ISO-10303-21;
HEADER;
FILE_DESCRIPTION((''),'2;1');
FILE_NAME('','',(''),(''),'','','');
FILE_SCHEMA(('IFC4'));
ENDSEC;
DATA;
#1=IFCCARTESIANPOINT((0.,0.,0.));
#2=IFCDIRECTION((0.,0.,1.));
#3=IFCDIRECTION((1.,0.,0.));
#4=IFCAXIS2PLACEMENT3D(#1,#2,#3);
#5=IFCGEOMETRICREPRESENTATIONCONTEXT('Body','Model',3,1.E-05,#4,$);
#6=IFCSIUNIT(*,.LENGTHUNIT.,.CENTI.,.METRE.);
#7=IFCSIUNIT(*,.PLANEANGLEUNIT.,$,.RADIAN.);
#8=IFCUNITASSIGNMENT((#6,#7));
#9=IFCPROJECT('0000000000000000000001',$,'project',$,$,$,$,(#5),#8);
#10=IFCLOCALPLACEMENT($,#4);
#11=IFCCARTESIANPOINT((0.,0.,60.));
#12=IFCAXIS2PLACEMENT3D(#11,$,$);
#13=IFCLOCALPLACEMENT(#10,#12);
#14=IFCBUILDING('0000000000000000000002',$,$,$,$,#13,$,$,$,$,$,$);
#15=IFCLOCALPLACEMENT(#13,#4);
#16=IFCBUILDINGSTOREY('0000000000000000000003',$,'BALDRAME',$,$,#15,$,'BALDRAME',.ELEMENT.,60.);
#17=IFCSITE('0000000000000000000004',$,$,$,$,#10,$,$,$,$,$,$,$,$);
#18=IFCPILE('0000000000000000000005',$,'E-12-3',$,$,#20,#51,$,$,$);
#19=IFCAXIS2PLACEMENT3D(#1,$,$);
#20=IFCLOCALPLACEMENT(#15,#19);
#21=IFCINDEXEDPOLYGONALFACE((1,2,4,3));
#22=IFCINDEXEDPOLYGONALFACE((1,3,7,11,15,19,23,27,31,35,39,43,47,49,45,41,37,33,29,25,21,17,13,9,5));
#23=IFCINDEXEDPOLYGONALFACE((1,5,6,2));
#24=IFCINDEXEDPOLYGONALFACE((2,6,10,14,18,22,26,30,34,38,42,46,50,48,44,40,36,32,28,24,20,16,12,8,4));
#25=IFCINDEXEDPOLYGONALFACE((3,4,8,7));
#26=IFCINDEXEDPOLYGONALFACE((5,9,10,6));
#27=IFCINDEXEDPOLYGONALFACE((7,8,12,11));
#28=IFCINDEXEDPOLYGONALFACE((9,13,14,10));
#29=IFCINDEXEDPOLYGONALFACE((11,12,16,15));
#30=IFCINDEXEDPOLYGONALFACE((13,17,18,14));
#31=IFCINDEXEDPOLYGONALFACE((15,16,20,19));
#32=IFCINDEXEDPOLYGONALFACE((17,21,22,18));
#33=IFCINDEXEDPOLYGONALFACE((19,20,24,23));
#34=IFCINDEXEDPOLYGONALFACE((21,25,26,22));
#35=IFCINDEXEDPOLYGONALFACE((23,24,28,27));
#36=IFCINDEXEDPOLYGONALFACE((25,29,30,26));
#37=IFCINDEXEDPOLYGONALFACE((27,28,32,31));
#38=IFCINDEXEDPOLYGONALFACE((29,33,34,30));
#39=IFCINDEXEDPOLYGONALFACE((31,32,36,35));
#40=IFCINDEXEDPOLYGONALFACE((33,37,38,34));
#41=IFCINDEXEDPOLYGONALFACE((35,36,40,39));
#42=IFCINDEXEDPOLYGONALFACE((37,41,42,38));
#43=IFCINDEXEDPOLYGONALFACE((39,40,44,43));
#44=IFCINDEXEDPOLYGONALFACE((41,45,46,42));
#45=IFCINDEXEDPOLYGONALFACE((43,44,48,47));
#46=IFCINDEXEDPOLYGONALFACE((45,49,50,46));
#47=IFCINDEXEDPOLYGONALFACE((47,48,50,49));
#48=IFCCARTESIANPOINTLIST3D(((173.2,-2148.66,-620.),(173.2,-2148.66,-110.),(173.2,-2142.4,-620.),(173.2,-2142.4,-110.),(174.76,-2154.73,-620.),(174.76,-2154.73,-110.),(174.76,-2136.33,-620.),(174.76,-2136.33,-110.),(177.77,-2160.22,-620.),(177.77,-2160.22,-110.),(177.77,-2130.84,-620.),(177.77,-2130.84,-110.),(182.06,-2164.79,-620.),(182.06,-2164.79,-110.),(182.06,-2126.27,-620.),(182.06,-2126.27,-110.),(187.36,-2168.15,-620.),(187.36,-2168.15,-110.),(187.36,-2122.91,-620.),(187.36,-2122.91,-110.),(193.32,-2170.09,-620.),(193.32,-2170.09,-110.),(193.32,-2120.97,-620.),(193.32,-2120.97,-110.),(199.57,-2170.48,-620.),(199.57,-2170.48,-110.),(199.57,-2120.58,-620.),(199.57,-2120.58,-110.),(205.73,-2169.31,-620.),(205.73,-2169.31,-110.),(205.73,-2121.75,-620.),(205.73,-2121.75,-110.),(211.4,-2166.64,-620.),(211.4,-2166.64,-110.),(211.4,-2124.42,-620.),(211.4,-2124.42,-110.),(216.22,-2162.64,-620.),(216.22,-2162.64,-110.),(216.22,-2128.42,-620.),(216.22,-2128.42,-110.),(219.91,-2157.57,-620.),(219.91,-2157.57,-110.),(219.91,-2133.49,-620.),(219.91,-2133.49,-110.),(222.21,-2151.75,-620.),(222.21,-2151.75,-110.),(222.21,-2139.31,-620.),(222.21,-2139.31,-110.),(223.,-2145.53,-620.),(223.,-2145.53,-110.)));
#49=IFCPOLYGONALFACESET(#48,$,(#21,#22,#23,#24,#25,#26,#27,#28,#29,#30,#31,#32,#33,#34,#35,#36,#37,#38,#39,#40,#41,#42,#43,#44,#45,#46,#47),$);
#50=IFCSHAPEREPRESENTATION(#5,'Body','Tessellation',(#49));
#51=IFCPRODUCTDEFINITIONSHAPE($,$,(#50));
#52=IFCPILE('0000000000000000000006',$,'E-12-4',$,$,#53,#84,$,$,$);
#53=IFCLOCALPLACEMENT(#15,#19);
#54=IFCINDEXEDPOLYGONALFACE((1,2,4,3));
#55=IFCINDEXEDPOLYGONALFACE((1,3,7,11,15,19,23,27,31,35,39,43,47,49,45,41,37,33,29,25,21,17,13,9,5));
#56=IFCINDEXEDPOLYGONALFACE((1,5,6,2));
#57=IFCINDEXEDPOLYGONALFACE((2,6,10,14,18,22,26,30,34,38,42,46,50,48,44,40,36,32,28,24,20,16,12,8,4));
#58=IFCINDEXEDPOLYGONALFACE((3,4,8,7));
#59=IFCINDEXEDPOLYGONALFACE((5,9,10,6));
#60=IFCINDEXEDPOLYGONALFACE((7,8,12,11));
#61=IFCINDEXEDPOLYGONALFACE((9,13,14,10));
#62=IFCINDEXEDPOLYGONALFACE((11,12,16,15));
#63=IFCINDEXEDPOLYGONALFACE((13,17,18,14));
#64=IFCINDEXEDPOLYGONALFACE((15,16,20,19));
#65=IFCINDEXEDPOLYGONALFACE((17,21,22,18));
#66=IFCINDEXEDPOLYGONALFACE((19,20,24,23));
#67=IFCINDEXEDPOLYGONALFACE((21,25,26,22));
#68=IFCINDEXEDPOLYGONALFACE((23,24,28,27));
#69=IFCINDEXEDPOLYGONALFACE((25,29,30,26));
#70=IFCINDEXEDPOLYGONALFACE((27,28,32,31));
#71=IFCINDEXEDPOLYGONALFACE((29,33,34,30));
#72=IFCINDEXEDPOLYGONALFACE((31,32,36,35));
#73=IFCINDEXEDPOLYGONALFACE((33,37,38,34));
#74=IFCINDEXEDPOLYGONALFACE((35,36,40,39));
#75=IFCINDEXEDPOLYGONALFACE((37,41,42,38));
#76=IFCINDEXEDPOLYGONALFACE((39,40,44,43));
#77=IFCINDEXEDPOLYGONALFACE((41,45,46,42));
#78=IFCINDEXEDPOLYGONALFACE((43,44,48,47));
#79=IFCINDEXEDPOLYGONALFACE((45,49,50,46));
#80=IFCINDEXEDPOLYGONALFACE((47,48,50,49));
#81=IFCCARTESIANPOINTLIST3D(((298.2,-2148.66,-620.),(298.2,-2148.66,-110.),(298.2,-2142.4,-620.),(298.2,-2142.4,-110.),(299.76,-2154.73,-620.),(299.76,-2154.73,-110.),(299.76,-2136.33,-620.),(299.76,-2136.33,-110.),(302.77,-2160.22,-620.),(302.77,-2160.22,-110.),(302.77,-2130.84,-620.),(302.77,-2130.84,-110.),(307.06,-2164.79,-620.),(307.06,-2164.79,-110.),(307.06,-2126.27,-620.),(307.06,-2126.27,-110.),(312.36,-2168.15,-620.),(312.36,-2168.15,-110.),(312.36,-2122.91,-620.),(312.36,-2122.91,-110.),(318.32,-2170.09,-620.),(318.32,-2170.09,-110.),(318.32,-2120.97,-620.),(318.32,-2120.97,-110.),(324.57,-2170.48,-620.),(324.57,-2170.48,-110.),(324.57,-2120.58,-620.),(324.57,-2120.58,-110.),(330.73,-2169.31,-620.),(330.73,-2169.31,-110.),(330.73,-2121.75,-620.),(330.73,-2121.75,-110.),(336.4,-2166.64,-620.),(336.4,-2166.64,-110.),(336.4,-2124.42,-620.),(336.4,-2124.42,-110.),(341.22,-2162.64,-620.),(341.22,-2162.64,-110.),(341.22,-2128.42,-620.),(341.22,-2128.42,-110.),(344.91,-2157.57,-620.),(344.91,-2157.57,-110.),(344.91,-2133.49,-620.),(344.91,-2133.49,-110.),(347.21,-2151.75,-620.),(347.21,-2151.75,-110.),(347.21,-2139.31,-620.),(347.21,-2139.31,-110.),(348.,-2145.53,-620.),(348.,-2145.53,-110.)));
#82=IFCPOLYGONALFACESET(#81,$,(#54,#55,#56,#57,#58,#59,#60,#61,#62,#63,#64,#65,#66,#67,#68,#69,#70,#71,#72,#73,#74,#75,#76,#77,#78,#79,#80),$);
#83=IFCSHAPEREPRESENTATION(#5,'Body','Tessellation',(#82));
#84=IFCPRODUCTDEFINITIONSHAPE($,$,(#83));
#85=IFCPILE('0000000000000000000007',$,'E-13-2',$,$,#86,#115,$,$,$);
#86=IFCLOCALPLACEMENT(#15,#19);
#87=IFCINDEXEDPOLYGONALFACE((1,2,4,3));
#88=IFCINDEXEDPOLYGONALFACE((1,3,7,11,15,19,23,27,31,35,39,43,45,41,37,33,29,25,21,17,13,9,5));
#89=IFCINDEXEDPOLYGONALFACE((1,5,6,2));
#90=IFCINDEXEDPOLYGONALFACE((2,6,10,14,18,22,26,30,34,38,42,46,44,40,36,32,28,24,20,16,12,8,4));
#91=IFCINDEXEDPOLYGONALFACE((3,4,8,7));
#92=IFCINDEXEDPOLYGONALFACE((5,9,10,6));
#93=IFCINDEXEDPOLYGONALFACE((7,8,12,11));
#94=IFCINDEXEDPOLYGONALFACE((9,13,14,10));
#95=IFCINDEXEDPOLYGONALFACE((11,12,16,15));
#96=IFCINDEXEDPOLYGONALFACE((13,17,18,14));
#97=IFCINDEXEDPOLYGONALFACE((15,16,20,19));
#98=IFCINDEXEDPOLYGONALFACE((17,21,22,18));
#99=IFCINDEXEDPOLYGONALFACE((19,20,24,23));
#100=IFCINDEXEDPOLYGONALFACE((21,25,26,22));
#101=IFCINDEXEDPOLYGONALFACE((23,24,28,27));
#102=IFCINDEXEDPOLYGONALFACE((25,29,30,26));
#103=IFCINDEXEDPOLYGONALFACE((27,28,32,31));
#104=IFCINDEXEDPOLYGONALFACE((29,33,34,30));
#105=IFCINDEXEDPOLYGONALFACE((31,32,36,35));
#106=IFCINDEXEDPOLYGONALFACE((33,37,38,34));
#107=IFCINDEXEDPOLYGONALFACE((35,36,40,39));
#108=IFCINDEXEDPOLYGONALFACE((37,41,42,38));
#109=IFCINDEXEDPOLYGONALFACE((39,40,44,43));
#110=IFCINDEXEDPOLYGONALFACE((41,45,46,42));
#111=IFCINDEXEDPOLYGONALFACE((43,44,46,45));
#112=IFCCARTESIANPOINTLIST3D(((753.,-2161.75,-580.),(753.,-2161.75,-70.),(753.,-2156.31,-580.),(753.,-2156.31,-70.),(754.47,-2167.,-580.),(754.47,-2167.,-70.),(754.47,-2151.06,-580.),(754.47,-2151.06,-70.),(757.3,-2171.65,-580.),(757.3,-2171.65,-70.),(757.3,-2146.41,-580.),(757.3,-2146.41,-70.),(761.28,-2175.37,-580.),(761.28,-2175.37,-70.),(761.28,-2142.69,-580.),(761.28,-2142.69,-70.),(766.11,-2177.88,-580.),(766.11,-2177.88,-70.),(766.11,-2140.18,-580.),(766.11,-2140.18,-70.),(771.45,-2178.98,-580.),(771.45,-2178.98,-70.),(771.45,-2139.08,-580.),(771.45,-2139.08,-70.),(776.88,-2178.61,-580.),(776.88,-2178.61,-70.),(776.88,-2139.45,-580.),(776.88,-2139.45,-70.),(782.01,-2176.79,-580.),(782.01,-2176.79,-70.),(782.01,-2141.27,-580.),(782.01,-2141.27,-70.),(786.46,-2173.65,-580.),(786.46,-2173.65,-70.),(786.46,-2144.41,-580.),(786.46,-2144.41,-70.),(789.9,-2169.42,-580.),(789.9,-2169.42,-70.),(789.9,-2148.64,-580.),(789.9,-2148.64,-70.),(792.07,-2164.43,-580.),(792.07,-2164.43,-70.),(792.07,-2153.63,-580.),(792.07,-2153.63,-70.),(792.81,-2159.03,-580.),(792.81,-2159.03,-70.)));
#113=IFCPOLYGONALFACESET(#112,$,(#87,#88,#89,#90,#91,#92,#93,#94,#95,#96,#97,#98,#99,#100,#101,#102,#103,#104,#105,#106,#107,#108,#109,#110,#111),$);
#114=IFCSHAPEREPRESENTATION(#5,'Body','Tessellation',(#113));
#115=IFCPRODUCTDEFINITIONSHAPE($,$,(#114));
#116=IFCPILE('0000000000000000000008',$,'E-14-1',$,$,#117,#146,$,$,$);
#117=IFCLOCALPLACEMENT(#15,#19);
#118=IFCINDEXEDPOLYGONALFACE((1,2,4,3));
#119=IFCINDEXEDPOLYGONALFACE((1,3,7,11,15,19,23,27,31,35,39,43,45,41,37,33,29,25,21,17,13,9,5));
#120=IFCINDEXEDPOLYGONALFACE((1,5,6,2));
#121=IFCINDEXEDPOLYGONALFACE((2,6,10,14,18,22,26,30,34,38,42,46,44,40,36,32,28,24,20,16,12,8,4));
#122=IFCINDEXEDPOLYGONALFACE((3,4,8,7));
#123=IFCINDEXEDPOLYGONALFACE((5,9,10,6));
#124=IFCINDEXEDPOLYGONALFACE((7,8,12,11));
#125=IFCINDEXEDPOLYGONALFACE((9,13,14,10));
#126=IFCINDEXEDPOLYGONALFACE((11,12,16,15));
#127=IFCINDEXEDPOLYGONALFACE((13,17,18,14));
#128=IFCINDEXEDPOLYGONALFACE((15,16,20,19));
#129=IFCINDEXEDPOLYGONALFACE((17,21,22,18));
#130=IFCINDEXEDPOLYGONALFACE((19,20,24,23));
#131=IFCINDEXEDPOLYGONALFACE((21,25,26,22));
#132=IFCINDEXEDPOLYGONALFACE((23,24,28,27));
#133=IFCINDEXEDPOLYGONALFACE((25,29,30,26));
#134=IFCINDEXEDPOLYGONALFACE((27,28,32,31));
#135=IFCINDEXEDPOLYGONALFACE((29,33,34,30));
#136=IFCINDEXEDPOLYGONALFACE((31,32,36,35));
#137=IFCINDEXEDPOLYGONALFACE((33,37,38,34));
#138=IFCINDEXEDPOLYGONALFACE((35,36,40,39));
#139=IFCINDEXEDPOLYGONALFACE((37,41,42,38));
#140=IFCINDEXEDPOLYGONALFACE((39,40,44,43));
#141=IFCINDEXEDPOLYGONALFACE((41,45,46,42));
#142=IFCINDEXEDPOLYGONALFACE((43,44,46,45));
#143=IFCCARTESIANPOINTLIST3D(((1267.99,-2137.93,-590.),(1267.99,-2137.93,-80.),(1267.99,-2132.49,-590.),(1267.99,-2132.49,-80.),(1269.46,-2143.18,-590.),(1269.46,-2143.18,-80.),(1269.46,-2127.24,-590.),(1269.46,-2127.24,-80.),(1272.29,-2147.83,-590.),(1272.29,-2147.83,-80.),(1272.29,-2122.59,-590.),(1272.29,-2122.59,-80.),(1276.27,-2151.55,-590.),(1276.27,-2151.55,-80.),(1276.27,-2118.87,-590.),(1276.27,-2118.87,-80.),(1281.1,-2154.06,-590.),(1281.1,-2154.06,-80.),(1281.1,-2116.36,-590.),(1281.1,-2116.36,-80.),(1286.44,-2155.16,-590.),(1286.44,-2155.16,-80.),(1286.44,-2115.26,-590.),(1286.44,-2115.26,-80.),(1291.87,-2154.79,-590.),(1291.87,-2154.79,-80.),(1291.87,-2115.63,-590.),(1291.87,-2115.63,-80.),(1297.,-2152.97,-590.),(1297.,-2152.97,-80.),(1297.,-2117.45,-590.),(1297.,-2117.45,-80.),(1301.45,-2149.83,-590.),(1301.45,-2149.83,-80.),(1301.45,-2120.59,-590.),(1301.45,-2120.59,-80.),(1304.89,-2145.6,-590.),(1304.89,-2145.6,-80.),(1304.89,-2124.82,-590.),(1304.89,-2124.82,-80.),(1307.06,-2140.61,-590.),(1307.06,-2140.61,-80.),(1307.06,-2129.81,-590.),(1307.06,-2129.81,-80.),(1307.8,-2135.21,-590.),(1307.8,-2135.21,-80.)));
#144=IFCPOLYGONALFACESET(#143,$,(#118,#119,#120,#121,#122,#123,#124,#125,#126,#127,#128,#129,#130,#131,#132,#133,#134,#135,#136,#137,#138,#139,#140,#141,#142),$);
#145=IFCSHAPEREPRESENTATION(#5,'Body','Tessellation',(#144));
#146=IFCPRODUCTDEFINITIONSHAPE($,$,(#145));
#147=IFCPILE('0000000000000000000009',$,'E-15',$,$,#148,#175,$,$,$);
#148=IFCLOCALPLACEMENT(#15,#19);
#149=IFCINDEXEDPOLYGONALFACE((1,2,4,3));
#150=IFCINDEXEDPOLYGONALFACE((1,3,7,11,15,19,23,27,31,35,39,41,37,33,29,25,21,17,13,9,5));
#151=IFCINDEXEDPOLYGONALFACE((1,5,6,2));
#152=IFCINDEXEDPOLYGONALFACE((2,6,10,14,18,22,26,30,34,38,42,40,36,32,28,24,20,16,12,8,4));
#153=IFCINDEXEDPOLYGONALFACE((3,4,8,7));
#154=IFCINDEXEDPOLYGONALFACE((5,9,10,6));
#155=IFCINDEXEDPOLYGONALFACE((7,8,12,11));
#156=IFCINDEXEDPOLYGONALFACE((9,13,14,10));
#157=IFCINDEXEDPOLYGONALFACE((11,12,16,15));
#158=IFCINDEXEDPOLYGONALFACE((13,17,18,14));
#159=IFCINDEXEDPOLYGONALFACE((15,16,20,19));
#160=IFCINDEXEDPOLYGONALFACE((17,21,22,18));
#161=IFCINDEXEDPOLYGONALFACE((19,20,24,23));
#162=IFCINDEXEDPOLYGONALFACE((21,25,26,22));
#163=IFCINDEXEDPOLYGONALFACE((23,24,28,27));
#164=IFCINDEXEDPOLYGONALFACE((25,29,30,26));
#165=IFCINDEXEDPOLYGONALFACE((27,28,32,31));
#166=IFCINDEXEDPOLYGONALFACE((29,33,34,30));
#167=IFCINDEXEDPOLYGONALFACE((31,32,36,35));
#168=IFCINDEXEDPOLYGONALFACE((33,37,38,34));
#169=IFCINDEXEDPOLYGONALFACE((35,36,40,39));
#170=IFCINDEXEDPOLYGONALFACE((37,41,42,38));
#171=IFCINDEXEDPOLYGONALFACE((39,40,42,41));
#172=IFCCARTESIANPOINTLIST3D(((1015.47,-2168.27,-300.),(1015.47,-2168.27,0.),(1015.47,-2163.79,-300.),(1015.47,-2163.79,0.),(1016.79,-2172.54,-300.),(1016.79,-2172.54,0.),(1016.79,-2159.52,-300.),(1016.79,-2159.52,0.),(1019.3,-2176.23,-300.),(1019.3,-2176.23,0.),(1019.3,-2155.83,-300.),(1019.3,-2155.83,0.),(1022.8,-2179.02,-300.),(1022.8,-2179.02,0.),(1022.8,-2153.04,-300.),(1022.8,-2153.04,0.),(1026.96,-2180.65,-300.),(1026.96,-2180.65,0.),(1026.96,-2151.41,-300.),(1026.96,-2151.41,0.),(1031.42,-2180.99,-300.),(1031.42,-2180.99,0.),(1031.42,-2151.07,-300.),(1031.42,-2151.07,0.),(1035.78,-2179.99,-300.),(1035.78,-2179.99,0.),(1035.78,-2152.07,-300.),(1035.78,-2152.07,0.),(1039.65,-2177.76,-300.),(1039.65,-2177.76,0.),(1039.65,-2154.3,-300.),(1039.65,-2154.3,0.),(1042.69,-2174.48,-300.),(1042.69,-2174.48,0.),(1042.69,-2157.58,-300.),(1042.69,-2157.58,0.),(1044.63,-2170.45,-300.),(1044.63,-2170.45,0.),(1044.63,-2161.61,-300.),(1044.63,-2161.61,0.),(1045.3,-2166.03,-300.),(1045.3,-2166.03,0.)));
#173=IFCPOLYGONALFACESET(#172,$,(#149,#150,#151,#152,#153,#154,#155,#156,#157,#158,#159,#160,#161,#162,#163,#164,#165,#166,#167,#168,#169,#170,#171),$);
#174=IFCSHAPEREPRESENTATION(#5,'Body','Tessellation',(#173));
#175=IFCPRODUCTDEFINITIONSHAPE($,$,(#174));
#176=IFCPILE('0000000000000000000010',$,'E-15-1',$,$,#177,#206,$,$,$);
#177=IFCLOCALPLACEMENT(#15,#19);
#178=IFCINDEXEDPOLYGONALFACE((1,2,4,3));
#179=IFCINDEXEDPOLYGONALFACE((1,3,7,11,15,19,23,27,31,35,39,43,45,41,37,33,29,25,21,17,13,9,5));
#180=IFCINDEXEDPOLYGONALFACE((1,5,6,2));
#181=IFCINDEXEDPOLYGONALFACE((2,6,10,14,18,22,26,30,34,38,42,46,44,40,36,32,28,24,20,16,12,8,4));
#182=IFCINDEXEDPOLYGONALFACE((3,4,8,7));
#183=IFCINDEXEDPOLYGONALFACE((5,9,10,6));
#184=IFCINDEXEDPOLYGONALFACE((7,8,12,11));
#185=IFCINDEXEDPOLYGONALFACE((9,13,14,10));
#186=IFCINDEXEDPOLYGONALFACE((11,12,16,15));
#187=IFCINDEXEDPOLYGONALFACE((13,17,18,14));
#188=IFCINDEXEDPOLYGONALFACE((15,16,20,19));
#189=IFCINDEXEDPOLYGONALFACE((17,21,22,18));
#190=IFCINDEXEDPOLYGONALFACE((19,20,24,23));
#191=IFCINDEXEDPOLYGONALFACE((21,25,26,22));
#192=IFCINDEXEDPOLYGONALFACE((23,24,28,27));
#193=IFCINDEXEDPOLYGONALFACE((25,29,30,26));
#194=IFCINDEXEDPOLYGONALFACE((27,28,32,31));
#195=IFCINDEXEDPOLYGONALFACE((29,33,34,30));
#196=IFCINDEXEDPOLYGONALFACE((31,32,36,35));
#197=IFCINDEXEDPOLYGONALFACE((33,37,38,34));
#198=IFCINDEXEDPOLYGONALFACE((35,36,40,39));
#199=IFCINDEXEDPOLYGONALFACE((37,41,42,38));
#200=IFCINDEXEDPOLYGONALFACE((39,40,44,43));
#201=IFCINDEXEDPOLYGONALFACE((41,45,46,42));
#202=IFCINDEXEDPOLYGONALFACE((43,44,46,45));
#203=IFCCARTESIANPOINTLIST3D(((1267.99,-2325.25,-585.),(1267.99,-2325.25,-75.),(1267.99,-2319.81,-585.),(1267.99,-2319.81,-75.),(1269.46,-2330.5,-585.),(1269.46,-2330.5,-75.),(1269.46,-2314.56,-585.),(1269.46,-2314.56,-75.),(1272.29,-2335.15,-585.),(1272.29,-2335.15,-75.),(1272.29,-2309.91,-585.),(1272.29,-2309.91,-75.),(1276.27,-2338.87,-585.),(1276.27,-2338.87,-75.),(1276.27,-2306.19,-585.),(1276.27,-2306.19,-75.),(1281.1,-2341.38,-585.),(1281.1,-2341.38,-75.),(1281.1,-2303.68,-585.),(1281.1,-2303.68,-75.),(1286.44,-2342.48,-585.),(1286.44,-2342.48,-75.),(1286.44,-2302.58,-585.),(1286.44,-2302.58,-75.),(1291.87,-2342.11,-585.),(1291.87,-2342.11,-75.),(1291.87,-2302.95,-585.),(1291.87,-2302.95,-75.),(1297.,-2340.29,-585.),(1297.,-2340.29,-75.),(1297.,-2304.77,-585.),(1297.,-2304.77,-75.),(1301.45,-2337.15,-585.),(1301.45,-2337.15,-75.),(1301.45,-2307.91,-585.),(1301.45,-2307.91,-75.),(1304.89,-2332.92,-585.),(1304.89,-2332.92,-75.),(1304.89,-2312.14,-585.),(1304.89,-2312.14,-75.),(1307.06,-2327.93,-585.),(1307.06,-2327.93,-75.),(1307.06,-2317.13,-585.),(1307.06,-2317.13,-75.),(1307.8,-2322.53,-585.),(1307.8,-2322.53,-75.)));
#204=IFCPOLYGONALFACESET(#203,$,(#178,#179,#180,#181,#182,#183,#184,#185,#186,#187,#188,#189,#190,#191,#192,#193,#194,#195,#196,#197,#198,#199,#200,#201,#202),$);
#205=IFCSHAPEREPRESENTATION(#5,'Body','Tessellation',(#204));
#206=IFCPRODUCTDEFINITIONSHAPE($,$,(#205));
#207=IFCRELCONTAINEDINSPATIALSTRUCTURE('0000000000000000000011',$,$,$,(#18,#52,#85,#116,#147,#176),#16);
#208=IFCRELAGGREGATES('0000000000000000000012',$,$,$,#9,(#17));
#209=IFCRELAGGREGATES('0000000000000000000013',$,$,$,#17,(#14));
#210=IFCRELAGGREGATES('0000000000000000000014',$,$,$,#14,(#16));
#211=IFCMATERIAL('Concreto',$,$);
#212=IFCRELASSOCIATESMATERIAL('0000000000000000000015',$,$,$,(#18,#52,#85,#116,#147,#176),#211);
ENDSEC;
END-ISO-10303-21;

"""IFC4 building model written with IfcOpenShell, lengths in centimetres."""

from ifc_helpers import new_model, si_unit, frame, origin_with_axes, origin_2d_with_axis, place, context, project, spatial, circle, extrude, material, element, save


model = new_model("IFC4")

# Units and contexts
model_context = context("Model", 3, precision=1e-05, world=origin_with_axes(), identifier="Body")
ifc_project = project(units=[si_unit("LENGTHUNIT", "METRE", prefix="CENTI"), si_unit("PLANEANGLEUNIT", "RADIAN")], contexts=[model_context])

# Site, building, storey
site_placement = place(None, origin_with_axes())
site = spatial("IfcSite", under=ifc_project, at=site_placement)
building_placement = place(site_placement, frame((0.0, 0.0, 60.0)))
building = spatial("IfcBuilding", under=site, at=building_placement)
storey_placement = place(building_placement, origin_with_axes())
storey = spatial("IfcBuildingStorey", under=building, at=storey_placement, Name="BALDRAME", LongName="BALDRAME", CompositionType="ELEMENT", Elevation=60.0)

# Piles
ifc_material = material(Name="Concreto")
for number, where, z_axis, x_axis, name in (
    (1, (198.0, -2145.53, -110.0), (0.0, 0.0, 1.0), (1.0, 0.0, 0.0), "E-12-3"),
    (2, (323.0, -2145.53, -110.0), (0.0, 0.0, 1.0), (1.0, 0.0, 0.0), "E-12-4"),
):
    element("IfcPile", number, at=place(storey_placement, frame(where, z_axis=z_axis, x_axis=x_axis)), inside=storey, material=ifc_material, Name=name, context=model_context, shape_type="SweptSolid", body=[
        extrude(circle(Radius=25.0, at=origin_2d_with_axis()), frame((0.0, 0.0, -510.0), z_axis=(0.0, 0.0, 1.0), x_axis=(1.0, 0.0, 0.0)), (0.0, 0.0, 1.0), 510.0),
    ])
for number, where, z_axis, x_axis, name in (
    (3, (772.81, -2159.03, -70.0), (0.0, 0.0, 1.0), (1.0, 0.0, 0.0), "E-13-2"),
    (4, (1287.8, -2135.21, -80.0), (0.0, 0.0, 1.0), (1.0, 0.0, 0.0), "E-14-1"),
):
    element("IfcPile", number, at=place(storey_placement, frame(where, z_axis=z_axis, x_axis=x_axis)), inside=storey, material=ifc_material, Name=name, context=model_context, shape_type="SweptSolid", body=[
        extrude(circle(Radius=20.0, at=origin_2d_with_axis()), frame((0.0, 0.0, -510.0), z_axis=(0.0, 0.0, 1.0), x_axis=(1.0, 0.0, 0.0)), (0.0, 0.0, 1.0), 510.0),
    ])
pile_1_placement = place(storey_placement, frame((1030.3, -2166.03, 0.0), z_axis=(0.0, 0.0, 1.0), x_axis=(1.0, 0.0, 0.0)))
element("IfcPile", 5, at=pile_1_placement, inside=storey, material=ifc_material, Name="E-15", context=model_context, shape_type="SolidModel", body=[
    extrude(circle(Radius=15.0, at=origin_2d_with_axis()), frame((0.0, 0.0, -300.0), z_axis=(0.0, 0.0, 1.0), x_axis=(1.0, 0.0, 0.0)), (0.0, 0.0, 1.0), 300.0),
])
for number, where, z_axis, x_axis, name in (
    (6, (1287.8, -2322.53, -75.0), (0.0, 0.0, 1.0), (1.0, 0.0, 0.0), "E-15-1"),
):
    element("IfcPile", number, at=place(storey_placement, frame(where, z_axis=z_axis, x_axis=x_axis)), inside=storey, material=ifc_material, Name=name, context=model_context, shape_type="SweptSolid", body=[
        extrude(circle(Radius=20.0, at=origin_2d_with_axis()), frame((0.0, 0.0, -510.0), z_axis=(0.0, 0.0, 1.0), x_axis=(1.0, 0.0, 0.0)), (0.0, 0.0, 1.0), 510.0),
    ])

save(model, "model.ifc")
